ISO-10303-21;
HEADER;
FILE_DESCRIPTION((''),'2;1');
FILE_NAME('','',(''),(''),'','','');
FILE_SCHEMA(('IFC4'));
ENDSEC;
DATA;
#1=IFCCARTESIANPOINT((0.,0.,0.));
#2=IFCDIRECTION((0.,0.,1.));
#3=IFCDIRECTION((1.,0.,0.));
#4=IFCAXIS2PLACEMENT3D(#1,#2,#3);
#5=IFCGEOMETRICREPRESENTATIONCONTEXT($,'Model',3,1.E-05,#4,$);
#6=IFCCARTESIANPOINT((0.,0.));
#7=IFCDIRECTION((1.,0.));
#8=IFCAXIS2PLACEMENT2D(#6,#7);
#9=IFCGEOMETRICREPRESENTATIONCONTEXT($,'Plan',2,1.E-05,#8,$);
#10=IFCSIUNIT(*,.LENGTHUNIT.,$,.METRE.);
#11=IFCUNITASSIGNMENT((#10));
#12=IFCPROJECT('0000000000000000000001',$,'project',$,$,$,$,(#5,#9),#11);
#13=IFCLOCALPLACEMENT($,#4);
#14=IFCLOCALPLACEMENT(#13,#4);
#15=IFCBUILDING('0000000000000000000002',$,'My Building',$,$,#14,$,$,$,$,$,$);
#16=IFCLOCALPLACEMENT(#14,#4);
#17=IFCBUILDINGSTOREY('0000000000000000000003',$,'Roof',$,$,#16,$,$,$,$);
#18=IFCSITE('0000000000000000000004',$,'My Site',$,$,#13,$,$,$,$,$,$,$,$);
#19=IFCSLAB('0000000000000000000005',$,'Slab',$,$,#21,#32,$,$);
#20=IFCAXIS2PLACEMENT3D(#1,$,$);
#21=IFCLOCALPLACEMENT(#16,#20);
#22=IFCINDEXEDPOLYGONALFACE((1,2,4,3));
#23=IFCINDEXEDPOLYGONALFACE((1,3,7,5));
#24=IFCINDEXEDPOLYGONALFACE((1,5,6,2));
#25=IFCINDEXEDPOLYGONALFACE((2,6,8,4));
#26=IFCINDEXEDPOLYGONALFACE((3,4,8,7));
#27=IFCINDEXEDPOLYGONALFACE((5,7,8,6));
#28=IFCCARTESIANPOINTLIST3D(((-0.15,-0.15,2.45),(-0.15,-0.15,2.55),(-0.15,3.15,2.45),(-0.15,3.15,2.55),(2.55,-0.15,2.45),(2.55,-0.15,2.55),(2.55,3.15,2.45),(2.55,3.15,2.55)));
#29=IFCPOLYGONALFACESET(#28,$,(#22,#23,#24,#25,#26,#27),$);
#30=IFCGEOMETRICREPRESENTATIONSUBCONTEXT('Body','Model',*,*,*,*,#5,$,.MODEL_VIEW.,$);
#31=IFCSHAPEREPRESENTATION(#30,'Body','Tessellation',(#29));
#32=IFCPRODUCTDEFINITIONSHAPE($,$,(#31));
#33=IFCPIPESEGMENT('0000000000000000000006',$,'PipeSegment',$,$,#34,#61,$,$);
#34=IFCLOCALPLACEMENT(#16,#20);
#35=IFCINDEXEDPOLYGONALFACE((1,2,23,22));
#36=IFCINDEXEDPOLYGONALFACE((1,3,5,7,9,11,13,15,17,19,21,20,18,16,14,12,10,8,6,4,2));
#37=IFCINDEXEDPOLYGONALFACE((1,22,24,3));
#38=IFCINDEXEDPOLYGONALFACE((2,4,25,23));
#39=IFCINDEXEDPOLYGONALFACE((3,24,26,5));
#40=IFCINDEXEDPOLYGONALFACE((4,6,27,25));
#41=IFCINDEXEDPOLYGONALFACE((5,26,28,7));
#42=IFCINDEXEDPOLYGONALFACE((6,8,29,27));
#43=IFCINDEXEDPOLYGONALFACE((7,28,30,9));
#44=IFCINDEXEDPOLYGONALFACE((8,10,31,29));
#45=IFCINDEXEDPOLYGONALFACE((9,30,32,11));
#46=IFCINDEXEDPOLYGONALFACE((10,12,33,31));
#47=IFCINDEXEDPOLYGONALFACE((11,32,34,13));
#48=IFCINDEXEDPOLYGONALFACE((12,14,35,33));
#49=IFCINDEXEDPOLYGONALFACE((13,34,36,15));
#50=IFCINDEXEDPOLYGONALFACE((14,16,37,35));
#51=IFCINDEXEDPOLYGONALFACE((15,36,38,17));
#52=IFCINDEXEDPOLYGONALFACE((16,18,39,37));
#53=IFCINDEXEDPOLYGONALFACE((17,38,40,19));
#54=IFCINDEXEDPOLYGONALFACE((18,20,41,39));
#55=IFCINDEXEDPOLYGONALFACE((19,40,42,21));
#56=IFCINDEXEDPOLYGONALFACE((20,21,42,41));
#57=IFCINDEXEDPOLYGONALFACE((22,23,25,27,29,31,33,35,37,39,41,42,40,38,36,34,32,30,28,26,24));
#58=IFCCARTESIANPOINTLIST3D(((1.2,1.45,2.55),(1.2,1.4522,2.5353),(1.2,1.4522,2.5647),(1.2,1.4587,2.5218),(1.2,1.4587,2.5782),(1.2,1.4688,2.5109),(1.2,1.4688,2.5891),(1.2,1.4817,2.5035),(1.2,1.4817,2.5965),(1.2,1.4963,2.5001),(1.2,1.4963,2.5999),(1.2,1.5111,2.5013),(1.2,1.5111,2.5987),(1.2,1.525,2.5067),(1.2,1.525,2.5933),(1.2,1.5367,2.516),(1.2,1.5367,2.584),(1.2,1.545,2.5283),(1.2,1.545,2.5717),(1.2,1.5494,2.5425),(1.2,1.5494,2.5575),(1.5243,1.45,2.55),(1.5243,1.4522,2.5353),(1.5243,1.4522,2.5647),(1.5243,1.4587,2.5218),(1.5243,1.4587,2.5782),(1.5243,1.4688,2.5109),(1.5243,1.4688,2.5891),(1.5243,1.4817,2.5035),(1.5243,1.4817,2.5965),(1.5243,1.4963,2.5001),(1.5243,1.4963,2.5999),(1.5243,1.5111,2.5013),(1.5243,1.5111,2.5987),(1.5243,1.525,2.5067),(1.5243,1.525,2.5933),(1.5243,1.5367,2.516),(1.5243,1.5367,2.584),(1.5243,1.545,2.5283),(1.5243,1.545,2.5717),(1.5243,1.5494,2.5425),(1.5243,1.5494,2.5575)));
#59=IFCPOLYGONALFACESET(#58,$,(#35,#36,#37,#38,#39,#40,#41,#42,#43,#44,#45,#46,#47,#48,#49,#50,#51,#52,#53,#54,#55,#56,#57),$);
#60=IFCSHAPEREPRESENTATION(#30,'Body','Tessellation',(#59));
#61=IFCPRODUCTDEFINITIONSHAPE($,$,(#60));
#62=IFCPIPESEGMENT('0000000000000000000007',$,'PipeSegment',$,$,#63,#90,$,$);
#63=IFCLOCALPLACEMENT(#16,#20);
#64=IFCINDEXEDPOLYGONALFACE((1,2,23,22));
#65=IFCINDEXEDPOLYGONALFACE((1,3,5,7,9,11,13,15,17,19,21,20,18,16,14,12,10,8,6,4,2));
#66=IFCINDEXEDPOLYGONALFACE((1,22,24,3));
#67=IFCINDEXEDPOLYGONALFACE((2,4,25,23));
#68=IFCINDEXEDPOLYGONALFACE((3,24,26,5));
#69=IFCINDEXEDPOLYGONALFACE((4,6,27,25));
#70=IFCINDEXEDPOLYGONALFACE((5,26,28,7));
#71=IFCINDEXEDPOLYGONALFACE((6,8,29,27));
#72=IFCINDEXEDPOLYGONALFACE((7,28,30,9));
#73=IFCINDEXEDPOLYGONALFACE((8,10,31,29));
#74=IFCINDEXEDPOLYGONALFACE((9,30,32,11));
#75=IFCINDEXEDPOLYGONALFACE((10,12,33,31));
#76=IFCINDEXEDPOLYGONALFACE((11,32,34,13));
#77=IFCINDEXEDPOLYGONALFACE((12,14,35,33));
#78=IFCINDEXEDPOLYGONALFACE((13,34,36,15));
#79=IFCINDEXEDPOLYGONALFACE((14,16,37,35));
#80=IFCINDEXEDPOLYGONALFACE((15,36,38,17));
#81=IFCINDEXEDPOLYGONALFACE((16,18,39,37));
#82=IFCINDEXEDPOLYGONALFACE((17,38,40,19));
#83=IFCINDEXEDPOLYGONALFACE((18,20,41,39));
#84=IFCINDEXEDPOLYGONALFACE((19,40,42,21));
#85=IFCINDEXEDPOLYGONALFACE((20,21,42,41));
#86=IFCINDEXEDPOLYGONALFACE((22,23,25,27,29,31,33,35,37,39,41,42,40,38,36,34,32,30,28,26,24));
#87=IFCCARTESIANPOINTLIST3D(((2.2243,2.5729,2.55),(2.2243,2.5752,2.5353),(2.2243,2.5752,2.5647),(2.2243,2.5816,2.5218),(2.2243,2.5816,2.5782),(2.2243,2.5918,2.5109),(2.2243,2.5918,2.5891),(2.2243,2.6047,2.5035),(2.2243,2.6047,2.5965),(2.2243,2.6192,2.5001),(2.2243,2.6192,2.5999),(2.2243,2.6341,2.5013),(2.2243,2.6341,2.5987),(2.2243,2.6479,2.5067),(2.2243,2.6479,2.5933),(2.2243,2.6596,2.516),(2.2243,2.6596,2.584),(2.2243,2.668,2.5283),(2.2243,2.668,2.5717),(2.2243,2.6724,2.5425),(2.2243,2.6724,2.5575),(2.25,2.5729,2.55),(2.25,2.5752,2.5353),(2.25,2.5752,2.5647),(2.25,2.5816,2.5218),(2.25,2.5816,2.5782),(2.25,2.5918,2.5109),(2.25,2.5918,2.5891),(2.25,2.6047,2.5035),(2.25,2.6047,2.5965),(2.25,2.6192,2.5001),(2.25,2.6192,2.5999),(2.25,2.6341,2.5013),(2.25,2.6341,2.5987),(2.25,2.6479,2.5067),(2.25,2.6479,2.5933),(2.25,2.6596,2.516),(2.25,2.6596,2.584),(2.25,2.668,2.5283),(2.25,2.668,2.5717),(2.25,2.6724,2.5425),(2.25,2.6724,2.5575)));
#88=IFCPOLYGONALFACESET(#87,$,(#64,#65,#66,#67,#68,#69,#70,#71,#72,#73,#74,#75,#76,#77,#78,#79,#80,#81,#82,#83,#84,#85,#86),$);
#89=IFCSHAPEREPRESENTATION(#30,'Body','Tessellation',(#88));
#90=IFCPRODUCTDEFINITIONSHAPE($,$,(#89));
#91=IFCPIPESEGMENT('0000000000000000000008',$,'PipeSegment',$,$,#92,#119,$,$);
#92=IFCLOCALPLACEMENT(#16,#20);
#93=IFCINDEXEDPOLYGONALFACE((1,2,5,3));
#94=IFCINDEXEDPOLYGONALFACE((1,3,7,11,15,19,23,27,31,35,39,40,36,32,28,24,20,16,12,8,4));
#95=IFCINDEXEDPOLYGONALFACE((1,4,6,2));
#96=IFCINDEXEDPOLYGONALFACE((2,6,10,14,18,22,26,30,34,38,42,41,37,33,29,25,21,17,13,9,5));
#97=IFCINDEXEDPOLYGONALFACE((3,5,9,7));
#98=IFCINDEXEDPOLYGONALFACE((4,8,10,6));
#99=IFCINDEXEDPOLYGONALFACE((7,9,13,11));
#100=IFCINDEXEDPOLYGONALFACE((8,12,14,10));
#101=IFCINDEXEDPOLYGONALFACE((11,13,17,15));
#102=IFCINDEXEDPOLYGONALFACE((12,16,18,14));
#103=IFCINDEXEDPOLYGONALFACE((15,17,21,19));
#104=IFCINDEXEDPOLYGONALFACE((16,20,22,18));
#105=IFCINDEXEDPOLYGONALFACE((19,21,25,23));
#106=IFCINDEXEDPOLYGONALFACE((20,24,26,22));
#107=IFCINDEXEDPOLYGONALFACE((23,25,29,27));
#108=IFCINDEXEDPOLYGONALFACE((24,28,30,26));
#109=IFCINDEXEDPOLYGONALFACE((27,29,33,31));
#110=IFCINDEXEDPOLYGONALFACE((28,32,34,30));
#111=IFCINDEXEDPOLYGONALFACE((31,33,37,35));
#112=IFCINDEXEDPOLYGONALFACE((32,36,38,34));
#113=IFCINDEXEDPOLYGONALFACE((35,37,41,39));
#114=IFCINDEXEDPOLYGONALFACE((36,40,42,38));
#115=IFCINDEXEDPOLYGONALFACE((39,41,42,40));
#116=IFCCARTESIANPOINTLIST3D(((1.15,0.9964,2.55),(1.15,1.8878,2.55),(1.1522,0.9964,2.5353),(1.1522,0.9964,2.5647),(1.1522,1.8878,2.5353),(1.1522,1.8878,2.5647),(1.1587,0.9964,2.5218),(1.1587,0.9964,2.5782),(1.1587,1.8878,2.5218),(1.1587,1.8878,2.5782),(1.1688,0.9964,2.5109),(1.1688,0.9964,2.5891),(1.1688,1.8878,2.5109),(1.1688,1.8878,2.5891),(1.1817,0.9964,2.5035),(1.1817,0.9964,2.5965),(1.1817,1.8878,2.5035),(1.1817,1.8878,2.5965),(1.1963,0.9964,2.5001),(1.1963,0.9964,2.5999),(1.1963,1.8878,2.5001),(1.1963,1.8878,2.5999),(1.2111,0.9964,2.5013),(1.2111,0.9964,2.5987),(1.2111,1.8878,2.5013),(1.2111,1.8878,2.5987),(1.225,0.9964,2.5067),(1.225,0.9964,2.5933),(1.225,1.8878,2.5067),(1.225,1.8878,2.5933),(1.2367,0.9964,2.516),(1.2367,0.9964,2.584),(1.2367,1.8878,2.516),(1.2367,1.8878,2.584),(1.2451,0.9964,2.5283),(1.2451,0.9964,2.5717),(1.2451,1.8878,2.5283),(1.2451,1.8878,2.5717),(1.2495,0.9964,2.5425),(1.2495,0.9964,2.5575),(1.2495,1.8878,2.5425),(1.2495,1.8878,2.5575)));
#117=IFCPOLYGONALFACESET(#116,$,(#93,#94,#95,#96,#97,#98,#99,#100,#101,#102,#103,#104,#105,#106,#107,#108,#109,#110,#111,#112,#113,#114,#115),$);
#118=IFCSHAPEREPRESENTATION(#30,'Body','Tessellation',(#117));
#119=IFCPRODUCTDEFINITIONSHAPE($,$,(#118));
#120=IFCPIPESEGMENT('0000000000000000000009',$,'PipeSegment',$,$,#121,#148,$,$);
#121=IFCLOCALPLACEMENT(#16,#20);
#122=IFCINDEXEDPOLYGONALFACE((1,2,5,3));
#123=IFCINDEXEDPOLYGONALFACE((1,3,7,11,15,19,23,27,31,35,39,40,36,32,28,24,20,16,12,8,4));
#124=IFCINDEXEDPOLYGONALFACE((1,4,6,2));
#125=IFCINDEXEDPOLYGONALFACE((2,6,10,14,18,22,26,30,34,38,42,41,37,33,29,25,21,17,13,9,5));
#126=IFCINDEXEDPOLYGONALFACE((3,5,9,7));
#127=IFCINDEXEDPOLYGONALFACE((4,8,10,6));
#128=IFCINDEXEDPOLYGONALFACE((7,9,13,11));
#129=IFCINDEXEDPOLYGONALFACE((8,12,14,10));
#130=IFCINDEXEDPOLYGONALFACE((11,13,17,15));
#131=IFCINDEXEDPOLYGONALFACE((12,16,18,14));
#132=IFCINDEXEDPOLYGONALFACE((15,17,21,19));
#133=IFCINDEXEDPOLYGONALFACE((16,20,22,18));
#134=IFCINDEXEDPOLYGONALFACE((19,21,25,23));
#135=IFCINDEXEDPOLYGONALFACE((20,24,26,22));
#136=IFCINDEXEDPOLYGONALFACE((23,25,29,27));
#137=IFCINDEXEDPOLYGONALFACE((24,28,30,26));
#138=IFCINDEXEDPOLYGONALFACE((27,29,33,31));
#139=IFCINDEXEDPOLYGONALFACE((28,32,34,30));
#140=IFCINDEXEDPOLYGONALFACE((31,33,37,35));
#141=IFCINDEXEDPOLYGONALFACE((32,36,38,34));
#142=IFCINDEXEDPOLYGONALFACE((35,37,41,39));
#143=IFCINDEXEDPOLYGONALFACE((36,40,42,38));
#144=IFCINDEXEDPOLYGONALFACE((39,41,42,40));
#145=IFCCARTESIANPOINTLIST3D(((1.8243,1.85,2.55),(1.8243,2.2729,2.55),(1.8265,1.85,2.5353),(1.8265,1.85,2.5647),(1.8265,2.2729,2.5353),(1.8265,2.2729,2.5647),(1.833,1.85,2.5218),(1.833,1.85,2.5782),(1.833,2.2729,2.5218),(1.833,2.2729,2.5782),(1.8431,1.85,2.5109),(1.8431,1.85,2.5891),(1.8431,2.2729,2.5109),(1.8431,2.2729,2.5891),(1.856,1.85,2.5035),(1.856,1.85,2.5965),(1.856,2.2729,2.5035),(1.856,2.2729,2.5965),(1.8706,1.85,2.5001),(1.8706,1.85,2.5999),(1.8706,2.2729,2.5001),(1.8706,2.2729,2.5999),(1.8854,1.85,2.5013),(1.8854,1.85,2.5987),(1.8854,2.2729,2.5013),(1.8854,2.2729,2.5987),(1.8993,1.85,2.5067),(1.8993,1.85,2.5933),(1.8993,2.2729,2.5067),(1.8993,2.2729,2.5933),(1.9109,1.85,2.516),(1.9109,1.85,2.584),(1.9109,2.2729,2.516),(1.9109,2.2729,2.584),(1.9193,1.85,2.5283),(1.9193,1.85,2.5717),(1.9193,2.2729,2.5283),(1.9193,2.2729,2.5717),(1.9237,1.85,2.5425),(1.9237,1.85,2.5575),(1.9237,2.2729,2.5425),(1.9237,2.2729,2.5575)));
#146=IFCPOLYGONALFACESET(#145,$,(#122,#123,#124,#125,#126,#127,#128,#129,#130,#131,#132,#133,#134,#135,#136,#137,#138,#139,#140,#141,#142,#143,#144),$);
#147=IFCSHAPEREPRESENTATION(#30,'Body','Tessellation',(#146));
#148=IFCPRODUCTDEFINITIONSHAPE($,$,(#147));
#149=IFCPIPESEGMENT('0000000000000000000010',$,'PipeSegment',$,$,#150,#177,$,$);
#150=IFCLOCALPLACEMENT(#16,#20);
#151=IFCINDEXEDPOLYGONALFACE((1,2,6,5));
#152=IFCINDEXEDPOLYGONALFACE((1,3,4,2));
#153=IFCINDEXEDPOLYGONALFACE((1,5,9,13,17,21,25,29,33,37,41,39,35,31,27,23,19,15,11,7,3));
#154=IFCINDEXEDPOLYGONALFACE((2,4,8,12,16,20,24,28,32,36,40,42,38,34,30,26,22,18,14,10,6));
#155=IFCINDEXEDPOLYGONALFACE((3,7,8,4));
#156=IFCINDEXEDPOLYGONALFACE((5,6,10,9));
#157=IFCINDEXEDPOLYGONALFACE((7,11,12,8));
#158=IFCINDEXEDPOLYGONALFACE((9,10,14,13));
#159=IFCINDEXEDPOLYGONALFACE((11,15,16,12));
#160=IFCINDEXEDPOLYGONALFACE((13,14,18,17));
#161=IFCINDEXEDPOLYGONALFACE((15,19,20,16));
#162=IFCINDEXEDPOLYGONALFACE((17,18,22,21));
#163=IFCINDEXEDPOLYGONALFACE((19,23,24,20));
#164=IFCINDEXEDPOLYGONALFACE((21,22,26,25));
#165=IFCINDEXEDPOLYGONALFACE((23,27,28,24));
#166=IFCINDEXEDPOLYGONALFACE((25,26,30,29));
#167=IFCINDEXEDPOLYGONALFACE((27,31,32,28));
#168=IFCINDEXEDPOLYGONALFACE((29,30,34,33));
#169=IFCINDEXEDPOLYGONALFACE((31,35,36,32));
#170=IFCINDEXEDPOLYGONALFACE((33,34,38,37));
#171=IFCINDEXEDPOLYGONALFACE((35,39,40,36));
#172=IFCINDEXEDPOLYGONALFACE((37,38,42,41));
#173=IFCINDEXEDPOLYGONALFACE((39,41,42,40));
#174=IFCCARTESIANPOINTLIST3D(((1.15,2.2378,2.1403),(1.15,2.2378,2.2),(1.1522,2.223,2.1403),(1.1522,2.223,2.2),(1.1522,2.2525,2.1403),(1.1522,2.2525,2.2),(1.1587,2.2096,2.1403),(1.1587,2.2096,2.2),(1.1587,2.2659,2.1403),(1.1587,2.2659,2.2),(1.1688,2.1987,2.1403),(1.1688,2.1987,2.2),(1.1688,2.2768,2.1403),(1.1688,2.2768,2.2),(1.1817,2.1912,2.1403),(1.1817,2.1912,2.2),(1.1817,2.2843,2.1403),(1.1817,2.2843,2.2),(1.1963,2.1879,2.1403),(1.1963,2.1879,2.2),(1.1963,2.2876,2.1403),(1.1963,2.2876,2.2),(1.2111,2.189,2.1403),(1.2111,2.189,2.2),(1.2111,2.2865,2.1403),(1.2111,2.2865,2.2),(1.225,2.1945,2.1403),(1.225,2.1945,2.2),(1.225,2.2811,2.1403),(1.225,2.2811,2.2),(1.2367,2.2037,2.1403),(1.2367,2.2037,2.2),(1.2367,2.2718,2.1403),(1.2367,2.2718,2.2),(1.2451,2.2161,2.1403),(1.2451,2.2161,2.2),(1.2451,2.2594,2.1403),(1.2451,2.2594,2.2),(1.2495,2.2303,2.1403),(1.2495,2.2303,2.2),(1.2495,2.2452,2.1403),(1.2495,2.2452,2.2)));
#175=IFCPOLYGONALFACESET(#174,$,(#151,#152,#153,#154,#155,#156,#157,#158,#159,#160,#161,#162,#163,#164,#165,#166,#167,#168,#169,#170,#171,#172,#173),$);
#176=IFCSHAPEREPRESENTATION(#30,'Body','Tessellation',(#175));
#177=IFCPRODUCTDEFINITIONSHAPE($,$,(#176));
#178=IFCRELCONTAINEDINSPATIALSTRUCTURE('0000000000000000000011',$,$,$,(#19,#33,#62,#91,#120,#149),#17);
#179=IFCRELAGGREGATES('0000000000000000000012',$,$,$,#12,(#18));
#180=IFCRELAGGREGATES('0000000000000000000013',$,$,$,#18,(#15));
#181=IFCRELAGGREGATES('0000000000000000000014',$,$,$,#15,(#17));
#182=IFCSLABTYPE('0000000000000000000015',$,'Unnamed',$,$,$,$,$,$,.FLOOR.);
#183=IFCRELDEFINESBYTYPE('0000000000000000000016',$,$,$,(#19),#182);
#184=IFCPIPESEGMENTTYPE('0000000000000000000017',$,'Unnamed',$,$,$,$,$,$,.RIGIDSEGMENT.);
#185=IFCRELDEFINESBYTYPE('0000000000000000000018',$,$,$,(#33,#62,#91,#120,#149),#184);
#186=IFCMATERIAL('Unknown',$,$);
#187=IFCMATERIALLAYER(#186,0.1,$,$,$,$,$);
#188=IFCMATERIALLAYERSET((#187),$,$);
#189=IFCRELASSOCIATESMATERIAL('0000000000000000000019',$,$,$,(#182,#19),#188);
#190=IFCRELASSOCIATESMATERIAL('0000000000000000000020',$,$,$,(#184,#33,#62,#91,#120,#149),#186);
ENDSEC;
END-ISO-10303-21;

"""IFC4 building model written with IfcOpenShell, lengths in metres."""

from ifc_helpers import new_model, si_unit, frame, origin_with_axes, origin_2d_with_axis, place, context, subcontext, project, spatial, indexed_curve, circle, outline, extrude, material, layer, layer_set, layer_usage, material_profile, profile_set, profile_usage, type_object, element, save


model = new_model("IFC4")

# Units and contexts
model_context = context("Model", 3, precision=1e-05, world=origin_with_axes())
plan_context = context("Plan", 2, precision=1e-05, world=origin_2d_with_axis())
body_context = subcontext(model_context, "Body", "Model", "MODEL_VIEW")
ifc_project = project(units=[si_unit("LENGTHUNIT", "METRE")], contexts=[model_context, plan_context])

# Site, building, storey
site_placement = place(None, origin_with_axes())
site = spatial("IfcSite", under=ifc_project, at=site_placement, Name="My Site")
building_placement = place(site_placement, origin_with_axes())
building = spatial("IfcBuilding", under=site, at=building_placement, Name="My Building")
storey_placement = place(building_placement, origin_with_axes())
storey = spatial("IfcBuildingStorey", under=building, at=storey_placement, Name="Roof")

# Slab
ifc_material = material(Name="Unknown")
ifc_layer = layer(ifc_material, 0.1)
ifc_layer_set = layer_set([ifc_layer])
ifc_layer_usage = layer_usage(ifc_layer_set, "AXIS3", "POSITIVE", -0.1)
slab_type = type_object("IfcSlabType", Name="Unnamed", PredefinedType="FLOOR", material=ifc_layer_set)
slab_placement = place(storey_placement, frame((-0.15, 3.15, 2.55), z_axis=(0.0, 0.0, 1.0), x_axis=(1.0, 0.0, 0.0)))
element("IfcSlab", 1, at=slab_placement, inside=storey, type_object=slab_type, material=ifc_layer_usage, Name="Slab", context=body_context, shape_type="SweptSolid", body=[
    extrude(outline(indexed_curve([(0.0, 0.0), (2.7, 0.0), (2.7, -3.3), (0.0, -3.3), (0.0, 0.0)])), frame((0.0, 0.0, -0.1), z_axis=(0.0, 0.0, 1.0), x_axis=(1.0, 0.0, 0.0)), (0.0, 0.0, 1.0), 0.1),
])

# Pipe segments
ifc_material_profile_1 = material_profile(ifc_material, circle(Radius=0.05))
ifc_profile_set_1 = profile_set([ifc_material_profile_1])
ifc_profile_usage_1 = profile_usage(ifc_profile_set_1, cardinal=5)
pipe_segment_type = type_object("IfcPipeSegmentType", Name="Unnamed", PredefinedType="RIGIDSEGMENT", material=ifc_profile_set_1)
pipe_segment_1_placement = place(storey_placement, frame((1.5243, 1.5, 2.55), z_axis=(-1.0, 0.0, 0.0), x_axis=(0.0, -1.0, 0.0)))
element("IfcPipeSegment", 2, at=pipe_segment_1_placement, inside=storey, type_object=pipe_segment_type, material=ifc_profile_usage_1, Name="PipeSegment", context=body_context, shape_type="SweptSolid", body=[
    extrude(circle(Radius=0.05), origin_with_axes(), (0.0, 0.0, 1.0), 0.3243),
])
ifc_profile_usage_2 = profile_usage(ifc_profile_set_1, cardinal=5)
pipe_segment_2_placement = place(storey_placement, frame((2.25, 2.6229, 2.55), z_axis=(-1.0, 0.0, 0.0), x_axis=(0.0, -1.0, 0.0)))
element("IfcPipeSegment", 3, at=pipe_segment_2_placement, inside=storey, type_object=pipe_segment_type, material=ifc_profile_usage_2, Name="PipeSegment", context=body_context, shape_type="SweptSolid", body=[
    extrude(circle(Radius=0.05), origin_with_axes(), (0.0, 0.0, 1.0), 0.0257),
])
ifc_profile_usage_3 = profile_usage(ifc_profile_set_1, cardinal=5)
pipe_segment_3_placement = place(storey_placement, frame((1.2, 0.9964, 2.55), z_axis=(0.0, 1.0, 0.0), x_axis=(-1.0, 0.0, 0.0)))
element("IfcPipeSegment", 4, at=pipe_segment_3_placement, inside=storey, type_object=pipe_segment_type, material=ifc_profile_usage_3, Name="PipeSegment", context=body_context, shape_type="SweptSolid", body=[
    extrude(circle(Radius=0.05), origin_with_axes(), (0.0, 0.0, 1.0), 0.8913),
])
ifc_profile_usage_4 = profile_usage(ifc_profile_set_1, cardinal=5)
pipe_segment_4_placement = place(storey_placement, frame((1.8743, 1.85, 2.55), z_axis=(0.0, 1.0, 0.0), x_axis=(-1.0, 0.0, 0.0)))
element("IfcPipeSegment", 5, at=pipe_segment_4_placement, inside=storey, type_object=pipe_segment_type, material=ifc_profile_usage_4, Name="PipeSegment", context=body_context, shape_type="SweptSolid", body=[
    extrude(circle(Radius=0.05), origin_with_axes(), (0.0, 0.0, 1.0), 0.4229),
])
ifc_profile_usage_5 = profile_usage(ifc_profile_set_1, cardinal=5)
pipe_segment_5_placement = place(storey_placement, frame((1.2, 2.2378, 2.2), z_axis=(0.0, 0.0, -1.0), x_axis=(-1.0, 0.0, 0.0)))
element("IfcPipeSegment", 6, at=pipe_segment_5_placement, inside=storey, type_object=pipe_segment_type, material=ifc_profile_usage_5, Name="PipeSegment", context=body_context, shape_type="SweptSolid", body=[
    extrude(circle(Radius=0.05), origin_with_axes(), (0.0, 0.0, 1.0), 0.0597),
])

save(model, "model.ifc")
